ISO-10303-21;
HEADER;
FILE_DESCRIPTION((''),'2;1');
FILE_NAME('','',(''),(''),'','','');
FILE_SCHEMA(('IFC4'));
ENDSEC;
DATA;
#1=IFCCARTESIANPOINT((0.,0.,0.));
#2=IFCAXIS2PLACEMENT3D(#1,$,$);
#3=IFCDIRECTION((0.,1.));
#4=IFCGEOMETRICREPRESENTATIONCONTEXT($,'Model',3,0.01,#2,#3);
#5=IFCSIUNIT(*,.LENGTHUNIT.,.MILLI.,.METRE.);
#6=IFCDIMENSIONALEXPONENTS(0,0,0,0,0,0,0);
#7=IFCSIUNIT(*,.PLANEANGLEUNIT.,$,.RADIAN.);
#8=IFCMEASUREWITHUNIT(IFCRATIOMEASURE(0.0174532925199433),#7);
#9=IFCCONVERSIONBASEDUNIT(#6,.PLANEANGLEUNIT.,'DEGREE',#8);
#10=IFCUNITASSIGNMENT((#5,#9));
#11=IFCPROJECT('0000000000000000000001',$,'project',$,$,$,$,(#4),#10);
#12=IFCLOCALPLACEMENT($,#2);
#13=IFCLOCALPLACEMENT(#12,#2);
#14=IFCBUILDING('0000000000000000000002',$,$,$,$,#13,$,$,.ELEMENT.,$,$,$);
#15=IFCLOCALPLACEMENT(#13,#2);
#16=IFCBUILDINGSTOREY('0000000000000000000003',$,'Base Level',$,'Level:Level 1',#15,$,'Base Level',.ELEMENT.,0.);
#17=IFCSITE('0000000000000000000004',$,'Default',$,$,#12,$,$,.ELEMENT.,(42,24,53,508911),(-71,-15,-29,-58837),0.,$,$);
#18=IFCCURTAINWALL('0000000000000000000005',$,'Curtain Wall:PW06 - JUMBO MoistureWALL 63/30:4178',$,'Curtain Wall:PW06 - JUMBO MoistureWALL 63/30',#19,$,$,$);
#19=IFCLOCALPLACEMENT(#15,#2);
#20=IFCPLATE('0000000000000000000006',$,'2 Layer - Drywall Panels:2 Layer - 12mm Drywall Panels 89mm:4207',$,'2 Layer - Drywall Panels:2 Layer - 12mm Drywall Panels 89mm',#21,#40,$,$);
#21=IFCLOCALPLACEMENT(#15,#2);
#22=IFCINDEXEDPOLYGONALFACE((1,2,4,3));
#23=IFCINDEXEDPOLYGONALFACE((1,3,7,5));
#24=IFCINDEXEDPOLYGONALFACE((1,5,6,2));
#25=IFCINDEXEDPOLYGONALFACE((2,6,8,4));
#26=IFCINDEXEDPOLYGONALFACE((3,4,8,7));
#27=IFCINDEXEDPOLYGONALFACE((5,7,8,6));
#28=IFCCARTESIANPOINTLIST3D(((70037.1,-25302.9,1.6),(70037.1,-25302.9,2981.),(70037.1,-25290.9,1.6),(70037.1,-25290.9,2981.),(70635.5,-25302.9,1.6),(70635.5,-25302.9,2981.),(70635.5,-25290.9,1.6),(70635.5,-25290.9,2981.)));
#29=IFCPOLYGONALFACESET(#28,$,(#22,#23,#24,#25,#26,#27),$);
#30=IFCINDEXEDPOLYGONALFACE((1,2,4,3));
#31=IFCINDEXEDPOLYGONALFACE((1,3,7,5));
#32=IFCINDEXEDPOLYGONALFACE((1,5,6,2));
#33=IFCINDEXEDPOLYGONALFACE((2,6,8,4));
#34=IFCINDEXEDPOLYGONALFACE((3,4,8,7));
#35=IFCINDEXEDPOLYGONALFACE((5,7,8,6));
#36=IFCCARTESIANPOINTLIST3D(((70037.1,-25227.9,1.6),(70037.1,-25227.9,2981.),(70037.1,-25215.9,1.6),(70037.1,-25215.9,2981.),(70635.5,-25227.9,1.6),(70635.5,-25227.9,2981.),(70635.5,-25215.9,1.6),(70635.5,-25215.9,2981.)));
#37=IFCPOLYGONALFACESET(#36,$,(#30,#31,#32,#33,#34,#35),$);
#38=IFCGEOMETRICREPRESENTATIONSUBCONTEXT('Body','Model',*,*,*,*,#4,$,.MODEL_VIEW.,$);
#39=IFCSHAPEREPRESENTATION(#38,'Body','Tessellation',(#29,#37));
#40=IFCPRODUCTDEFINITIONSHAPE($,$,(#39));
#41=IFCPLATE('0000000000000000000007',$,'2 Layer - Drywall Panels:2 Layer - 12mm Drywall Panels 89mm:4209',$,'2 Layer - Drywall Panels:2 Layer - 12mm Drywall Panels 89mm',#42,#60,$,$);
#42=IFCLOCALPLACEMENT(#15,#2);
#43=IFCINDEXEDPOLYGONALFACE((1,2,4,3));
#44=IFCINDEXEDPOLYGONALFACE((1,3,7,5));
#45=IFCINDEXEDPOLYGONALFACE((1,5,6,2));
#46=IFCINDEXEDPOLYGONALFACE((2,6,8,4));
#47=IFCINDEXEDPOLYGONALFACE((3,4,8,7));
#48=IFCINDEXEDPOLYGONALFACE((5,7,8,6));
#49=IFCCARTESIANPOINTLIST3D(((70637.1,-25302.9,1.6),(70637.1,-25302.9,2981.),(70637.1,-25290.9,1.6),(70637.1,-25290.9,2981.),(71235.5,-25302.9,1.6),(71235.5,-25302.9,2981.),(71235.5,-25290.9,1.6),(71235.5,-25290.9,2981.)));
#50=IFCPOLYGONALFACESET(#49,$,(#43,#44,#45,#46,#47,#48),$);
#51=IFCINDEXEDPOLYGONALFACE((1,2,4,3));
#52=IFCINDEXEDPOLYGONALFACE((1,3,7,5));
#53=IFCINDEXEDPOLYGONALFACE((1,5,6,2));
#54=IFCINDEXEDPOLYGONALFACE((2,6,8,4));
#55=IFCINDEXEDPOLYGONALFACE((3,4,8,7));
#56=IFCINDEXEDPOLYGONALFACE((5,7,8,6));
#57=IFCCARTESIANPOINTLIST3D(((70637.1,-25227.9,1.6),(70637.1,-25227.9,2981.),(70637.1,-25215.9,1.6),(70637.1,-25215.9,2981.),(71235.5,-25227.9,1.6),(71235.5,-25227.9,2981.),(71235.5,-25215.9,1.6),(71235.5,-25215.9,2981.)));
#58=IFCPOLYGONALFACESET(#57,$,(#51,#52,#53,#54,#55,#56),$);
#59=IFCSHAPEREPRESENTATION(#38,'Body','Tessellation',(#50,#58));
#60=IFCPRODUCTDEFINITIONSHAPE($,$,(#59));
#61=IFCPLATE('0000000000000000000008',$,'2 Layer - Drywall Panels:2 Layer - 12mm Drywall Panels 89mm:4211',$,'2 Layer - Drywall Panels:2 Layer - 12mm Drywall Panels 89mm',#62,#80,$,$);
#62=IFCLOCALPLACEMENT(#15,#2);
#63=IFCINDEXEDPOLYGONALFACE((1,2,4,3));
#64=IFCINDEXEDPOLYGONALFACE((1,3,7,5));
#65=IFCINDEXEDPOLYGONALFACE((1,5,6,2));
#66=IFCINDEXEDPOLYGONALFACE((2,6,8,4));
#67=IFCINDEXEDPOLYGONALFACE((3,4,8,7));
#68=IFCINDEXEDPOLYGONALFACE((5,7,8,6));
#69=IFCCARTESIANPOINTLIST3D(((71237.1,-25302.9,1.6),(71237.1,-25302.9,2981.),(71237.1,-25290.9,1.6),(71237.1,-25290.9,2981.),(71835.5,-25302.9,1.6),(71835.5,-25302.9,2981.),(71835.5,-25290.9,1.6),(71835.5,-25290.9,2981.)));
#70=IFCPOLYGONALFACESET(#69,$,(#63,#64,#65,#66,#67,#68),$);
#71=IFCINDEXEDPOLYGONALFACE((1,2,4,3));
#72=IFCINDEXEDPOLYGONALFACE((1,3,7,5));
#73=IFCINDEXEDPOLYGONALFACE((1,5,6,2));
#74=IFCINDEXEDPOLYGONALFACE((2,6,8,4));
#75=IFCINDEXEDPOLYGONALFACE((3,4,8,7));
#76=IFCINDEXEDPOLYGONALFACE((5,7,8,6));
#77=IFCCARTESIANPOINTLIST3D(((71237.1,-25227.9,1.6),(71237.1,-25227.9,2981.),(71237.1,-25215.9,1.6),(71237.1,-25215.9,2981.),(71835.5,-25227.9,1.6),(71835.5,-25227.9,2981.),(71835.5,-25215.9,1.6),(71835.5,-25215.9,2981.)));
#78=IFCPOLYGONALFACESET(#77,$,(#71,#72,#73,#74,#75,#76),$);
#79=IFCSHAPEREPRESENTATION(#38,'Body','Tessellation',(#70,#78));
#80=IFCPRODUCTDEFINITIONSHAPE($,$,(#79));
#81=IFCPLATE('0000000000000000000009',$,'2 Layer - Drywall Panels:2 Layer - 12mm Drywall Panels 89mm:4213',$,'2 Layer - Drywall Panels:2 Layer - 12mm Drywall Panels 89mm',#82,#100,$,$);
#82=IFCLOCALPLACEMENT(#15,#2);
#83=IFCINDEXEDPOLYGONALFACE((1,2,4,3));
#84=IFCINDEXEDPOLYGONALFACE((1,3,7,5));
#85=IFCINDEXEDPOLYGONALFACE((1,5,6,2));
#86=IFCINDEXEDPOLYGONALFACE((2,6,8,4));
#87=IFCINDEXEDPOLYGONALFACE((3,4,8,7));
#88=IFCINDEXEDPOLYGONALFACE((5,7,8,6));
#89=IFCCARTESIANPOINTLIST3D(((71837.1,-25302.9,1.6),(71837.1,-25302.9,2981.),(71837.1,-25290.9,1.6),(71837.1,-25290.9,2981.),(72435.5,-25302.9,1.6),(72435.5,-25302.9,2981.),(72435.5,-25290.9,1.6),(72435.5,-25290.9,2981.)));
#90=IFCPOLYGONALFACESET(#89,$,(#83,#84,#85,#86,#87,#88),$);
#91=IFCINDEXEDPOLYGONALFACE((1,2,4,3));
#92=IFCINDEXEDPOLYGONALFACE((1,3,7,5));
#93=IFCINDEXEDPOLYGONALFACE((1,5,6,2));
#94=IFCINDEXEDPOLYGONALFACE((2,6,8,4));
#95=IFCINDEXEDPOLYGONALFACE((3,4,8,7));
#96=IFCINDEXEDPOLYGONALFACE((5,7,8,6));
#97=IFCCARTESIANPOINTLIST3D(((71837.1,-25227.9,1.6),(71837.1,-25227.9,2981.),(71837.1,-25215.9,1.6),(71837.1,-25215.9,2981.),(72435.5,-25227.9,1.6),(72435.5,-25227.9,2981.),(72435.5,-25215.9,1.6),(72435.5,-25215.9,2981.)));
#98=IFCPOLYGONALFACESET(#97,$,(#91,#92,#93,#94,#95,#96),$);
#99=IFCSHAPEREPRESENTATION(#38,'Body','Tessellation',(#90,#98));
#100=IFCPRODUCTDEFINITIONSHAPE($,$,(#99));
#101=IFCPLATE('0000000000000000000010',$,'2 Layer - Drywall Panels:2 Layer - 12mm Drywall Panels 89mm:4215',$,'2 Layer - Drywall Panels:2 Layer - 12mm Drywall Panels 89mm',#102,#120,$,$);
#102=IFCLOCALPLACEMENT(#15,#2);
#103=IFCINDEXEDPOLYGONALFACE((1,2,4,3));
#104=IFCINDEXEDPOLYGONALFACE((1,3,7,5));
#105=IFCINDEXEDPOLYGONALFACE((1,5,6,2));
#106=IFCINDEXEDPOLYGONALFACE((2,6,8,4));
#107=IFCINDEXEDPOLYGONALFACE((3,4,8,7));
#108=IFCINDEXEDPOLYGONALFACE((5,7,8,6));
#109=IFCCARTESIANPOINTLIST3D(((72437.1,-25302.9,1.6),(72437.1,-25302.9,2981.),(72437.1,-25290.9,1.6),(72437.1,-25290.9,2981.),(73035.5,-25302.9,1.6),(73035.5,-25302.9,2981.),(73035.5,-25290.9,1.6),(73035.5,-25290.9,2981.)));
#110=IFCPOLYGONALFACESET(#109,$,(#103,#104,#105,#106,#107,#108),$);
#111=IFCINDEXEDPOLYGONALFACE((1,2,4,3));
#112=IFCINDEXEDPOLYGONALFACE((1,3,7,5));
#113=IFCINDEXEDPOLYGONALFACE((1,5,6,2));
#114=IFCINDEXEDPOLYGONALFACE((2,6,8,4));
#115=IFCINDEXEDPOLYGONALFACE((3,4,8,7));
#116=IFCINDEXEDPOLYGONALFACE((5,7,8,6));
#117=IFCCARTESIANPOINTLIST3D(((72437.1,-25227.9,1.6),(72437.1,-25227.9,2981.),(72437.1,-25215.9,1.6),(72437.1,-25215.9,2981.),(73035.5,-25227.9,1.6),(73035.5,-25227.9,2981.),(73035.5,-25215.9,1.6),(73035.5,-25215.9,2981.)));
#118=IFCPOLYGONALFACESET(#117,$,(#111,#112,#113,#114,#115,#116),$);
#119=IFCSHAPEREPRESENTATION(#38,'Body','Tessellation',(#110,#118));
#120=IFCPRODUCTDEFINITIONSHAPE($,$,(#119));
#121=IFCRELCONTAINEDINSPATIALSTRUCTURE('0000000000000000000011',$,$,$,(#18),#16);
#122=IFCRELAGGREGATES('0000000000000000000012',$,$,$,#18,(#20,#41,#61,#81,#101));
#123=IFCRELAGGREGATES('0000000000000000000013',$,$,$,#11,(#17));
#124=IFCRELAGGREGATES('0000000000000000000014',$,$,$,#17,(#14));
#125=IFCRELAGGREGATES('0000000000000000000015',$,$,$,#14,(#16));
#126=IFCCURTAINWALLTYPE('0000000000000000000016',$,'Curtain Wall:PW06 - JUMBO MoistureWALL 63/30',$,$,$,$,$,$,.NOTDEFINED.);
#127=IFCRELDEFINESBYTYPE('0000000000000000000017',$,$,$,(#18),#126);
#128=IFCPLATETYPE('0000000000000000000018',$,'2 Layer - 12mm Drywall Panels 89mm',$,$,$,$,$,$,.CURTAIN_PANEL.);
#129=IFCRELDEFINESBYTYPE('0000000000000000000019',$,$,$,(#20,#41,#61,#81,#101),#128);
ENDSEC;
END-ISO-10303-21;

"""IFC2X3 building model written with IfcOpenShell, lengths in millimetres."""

from ifc_helpers import new_model, entity, si_unit, converted_unit, direction, frame, frame_2d, origin, place, context, subcontext, project, spatial, rectangle, extrude, source, transform, mapped, type_object, type_shapes, element, aggregate, save


model = new_model("IFC2X3")

# Units and contexts
model_context = context("Model", 3, precision=0.01, world=origin(), true_north=direction((0.0, 1.0)))
body_context = subcontext(model_context, "Body", "Model", "MODEL_VIEW")
ifc_project = project(units=[si_unit("LENGTHUNIT", "METRE", prefix="MILLI"), converted_unit("PLANEANGLEUNIT", "DEGREE", entity("IfcRatioMeasure", 0.0174532925199433), si_unit("PLANEANGLEUNIT", "RADIAN"), dimensions=[0, 0, 0, 0, 0, 0, 0])], contexts=[model_context])

# Site, building, storey
site_placement = place(None, origin())
site = spatial("IfcSite", under=ifc_project, at=site_placement, Name="Default", CompositionType="ELEMENT", RefLatitude=(42, 24, 53, 508911), RefLongitude=(-71, -15, -29, -58837), RefElevation=0.0)
building_placement = place(site_placement, origin())
building = spatial("IfcBuilding", under=site, at=building_placement, CompositionType="ELEMENT")
storey_placement = place(building_placement, origin())
storey = spatial("IfcBuildingStorey", under=building, at=storey_placement, Name="Base Level", ObjectType="Level:Level 1", LongName="Base Level", CompositionType="ELEMENT", Elevation=0.0)

# Curtain wall, plates
curtain_wall_type = type_object("IfcCurtainWallType", Name="Curtain Wall:PW06 - JUMBO MoistureWALL 63/30", PredefinedType="NOTDEFINED")
curtain_wall_placement = place(building_placement, origin())
curtain_wall = element("IfcCurtainWall", 1, at=curtain_wall_placement, inside=storey, type_object=curtain_wall_type, Name="Curtain Wall:PW06 - JUMBO MoistureWALL 63/30:4178", ObjectType="Curtain Wall:PW06 - JUMBO MoistureWALL 63/30")
plate_type = type_object("IfcPlateType", Name="2 Layer - 12mm Drywall Panels 89mm", PredefinedType="CURTAIN_PANEL")
shared_shape_1 = source(origin(), body_context, "Body", "SweptSolid", [
    extrude(rectangle(XDim=598.4, YDim=12.0, at=frame_2d((0.0, 0.0), x_axis=(1.0, 0.0))), frame((0.0, -37.5, 0.0), z_axis=(0.0, 0.0, 1.0), x_axis=(-1.0, 0.0, 0.0)), (0.0, 0.0, 1.0), 2979.4),
    extrude(rectangle(XDim=12.0, YDim=598.4, at=frame_2d((0.0, 0.0), x_axis=(1.0, 0.0))), frame((0.0, 37.5, 0.0), z_axis=(0.0, 0.0, 1.0), x_axis=(0.0, 1.0, 0.0)), (0.0, 0.0, 1.0), 2979.4),
])
type_shapes(plate_type, [shared_shape_1])
plate_1_placement = place(curtain_wall_placement, frame((70336.3, -25259.4, 1.6)))
plate_1 = element("IfcPlate", 2, at=plate_1_placement, type_object=plate_type, Name="2 Layer - Drywall Panels:2 Layer - 12mm Drywall Panels 89mm:4207", ObjectType="2 Layer - Drywall Panels:2 Layer - 12mm Drywall Panels 89mm", context=body_context, shape_type="MappedRepresentation", body=[
    mapped(shared_shape_1, transform((0.0, 0.0, 0.0), scale=1.0)),
])
plate_2_placement = place(curtain_wall_placement, frame((70936.3, -25259.4, 1.6)))
plate_2 = element("IfcPlate", 3, at=plate_2_placement, type_object=plate_type, Name="2 Layer - Drywall Panels:2 Layer - 12mm Drywall Panels 89mm:4209", ObjectType="2 Layer - Drywall Panels:2 Layer - 12mm Drywall Panels 89mm", context=body_context, shape_type="MappedRepresentation", body=[
    mapped(shared_shape_1, transform((0.0, 0.0, 0.0), scale=1.0)),
])
plate_3_placement = place(curtain_wall_placement, frame((71536.3, -25259.4, 1.6)))
plate_3 = element("IfcPlate", 4, at=plate_3_placement, type_object=plate_type, Name="2 Layer - Drywall Panels:2 Layer - 12mm Drywall Panels 89mm:4211", ObjectType="2 Layer - Drywall Panels:2 Layer - 12mm Drywall Panels 89mm", context=body_context, shape_type="MappedRepresentation", body=[
    mapped(shared_shape_1, transform((0.0, 0.0, 0.0), scale=1.0)),
])
plate_4_placement = place(curtain_wall_placement, frame((72136.3, -25259.4, 1.6)))
plate_4 = element("IfcPlate", 5, at=plate_4_placement, type_object=plate_type, Name="2 Layer - Drywall Panels:2 Layer - 12mm Drywall Panels 89mm:4213", ObjectType="2 Layer - Drywall Panels:2 Layer - 12mm Drywall Panels 89mm", context=body_context, shape_type="MappedRepresentation", body=[
    mapped(shared_shape_1, transform((0.0, 0.0, 0.0), scale=1.0)),
])
plate_5_placement = place(curtain_wall_placement, frame((72736.3, -25259.4, 1.6)))
plate_5 = element("IfcPlate", 6, at=plate_5_placement, type_object=plate_type, Name="2 Layer - Drywall Panels:2 Layer - 12mm Drywall Panels 89mm:4215", ObjectType="2 Layer - Drywall Panels:2 Layer - 12mm Drywall Panels 89mm", context=body_context, shape_type="MappedRepresentation", body=[
    mapped(shared_shape_1, transform((0.0, 0.0, 0.0), scale=1.0)),
])
aggregate(curtain_wall, [plate_1, plate_2, plate_3, plate_4, plate_5])

save(model, "model.ifc")
